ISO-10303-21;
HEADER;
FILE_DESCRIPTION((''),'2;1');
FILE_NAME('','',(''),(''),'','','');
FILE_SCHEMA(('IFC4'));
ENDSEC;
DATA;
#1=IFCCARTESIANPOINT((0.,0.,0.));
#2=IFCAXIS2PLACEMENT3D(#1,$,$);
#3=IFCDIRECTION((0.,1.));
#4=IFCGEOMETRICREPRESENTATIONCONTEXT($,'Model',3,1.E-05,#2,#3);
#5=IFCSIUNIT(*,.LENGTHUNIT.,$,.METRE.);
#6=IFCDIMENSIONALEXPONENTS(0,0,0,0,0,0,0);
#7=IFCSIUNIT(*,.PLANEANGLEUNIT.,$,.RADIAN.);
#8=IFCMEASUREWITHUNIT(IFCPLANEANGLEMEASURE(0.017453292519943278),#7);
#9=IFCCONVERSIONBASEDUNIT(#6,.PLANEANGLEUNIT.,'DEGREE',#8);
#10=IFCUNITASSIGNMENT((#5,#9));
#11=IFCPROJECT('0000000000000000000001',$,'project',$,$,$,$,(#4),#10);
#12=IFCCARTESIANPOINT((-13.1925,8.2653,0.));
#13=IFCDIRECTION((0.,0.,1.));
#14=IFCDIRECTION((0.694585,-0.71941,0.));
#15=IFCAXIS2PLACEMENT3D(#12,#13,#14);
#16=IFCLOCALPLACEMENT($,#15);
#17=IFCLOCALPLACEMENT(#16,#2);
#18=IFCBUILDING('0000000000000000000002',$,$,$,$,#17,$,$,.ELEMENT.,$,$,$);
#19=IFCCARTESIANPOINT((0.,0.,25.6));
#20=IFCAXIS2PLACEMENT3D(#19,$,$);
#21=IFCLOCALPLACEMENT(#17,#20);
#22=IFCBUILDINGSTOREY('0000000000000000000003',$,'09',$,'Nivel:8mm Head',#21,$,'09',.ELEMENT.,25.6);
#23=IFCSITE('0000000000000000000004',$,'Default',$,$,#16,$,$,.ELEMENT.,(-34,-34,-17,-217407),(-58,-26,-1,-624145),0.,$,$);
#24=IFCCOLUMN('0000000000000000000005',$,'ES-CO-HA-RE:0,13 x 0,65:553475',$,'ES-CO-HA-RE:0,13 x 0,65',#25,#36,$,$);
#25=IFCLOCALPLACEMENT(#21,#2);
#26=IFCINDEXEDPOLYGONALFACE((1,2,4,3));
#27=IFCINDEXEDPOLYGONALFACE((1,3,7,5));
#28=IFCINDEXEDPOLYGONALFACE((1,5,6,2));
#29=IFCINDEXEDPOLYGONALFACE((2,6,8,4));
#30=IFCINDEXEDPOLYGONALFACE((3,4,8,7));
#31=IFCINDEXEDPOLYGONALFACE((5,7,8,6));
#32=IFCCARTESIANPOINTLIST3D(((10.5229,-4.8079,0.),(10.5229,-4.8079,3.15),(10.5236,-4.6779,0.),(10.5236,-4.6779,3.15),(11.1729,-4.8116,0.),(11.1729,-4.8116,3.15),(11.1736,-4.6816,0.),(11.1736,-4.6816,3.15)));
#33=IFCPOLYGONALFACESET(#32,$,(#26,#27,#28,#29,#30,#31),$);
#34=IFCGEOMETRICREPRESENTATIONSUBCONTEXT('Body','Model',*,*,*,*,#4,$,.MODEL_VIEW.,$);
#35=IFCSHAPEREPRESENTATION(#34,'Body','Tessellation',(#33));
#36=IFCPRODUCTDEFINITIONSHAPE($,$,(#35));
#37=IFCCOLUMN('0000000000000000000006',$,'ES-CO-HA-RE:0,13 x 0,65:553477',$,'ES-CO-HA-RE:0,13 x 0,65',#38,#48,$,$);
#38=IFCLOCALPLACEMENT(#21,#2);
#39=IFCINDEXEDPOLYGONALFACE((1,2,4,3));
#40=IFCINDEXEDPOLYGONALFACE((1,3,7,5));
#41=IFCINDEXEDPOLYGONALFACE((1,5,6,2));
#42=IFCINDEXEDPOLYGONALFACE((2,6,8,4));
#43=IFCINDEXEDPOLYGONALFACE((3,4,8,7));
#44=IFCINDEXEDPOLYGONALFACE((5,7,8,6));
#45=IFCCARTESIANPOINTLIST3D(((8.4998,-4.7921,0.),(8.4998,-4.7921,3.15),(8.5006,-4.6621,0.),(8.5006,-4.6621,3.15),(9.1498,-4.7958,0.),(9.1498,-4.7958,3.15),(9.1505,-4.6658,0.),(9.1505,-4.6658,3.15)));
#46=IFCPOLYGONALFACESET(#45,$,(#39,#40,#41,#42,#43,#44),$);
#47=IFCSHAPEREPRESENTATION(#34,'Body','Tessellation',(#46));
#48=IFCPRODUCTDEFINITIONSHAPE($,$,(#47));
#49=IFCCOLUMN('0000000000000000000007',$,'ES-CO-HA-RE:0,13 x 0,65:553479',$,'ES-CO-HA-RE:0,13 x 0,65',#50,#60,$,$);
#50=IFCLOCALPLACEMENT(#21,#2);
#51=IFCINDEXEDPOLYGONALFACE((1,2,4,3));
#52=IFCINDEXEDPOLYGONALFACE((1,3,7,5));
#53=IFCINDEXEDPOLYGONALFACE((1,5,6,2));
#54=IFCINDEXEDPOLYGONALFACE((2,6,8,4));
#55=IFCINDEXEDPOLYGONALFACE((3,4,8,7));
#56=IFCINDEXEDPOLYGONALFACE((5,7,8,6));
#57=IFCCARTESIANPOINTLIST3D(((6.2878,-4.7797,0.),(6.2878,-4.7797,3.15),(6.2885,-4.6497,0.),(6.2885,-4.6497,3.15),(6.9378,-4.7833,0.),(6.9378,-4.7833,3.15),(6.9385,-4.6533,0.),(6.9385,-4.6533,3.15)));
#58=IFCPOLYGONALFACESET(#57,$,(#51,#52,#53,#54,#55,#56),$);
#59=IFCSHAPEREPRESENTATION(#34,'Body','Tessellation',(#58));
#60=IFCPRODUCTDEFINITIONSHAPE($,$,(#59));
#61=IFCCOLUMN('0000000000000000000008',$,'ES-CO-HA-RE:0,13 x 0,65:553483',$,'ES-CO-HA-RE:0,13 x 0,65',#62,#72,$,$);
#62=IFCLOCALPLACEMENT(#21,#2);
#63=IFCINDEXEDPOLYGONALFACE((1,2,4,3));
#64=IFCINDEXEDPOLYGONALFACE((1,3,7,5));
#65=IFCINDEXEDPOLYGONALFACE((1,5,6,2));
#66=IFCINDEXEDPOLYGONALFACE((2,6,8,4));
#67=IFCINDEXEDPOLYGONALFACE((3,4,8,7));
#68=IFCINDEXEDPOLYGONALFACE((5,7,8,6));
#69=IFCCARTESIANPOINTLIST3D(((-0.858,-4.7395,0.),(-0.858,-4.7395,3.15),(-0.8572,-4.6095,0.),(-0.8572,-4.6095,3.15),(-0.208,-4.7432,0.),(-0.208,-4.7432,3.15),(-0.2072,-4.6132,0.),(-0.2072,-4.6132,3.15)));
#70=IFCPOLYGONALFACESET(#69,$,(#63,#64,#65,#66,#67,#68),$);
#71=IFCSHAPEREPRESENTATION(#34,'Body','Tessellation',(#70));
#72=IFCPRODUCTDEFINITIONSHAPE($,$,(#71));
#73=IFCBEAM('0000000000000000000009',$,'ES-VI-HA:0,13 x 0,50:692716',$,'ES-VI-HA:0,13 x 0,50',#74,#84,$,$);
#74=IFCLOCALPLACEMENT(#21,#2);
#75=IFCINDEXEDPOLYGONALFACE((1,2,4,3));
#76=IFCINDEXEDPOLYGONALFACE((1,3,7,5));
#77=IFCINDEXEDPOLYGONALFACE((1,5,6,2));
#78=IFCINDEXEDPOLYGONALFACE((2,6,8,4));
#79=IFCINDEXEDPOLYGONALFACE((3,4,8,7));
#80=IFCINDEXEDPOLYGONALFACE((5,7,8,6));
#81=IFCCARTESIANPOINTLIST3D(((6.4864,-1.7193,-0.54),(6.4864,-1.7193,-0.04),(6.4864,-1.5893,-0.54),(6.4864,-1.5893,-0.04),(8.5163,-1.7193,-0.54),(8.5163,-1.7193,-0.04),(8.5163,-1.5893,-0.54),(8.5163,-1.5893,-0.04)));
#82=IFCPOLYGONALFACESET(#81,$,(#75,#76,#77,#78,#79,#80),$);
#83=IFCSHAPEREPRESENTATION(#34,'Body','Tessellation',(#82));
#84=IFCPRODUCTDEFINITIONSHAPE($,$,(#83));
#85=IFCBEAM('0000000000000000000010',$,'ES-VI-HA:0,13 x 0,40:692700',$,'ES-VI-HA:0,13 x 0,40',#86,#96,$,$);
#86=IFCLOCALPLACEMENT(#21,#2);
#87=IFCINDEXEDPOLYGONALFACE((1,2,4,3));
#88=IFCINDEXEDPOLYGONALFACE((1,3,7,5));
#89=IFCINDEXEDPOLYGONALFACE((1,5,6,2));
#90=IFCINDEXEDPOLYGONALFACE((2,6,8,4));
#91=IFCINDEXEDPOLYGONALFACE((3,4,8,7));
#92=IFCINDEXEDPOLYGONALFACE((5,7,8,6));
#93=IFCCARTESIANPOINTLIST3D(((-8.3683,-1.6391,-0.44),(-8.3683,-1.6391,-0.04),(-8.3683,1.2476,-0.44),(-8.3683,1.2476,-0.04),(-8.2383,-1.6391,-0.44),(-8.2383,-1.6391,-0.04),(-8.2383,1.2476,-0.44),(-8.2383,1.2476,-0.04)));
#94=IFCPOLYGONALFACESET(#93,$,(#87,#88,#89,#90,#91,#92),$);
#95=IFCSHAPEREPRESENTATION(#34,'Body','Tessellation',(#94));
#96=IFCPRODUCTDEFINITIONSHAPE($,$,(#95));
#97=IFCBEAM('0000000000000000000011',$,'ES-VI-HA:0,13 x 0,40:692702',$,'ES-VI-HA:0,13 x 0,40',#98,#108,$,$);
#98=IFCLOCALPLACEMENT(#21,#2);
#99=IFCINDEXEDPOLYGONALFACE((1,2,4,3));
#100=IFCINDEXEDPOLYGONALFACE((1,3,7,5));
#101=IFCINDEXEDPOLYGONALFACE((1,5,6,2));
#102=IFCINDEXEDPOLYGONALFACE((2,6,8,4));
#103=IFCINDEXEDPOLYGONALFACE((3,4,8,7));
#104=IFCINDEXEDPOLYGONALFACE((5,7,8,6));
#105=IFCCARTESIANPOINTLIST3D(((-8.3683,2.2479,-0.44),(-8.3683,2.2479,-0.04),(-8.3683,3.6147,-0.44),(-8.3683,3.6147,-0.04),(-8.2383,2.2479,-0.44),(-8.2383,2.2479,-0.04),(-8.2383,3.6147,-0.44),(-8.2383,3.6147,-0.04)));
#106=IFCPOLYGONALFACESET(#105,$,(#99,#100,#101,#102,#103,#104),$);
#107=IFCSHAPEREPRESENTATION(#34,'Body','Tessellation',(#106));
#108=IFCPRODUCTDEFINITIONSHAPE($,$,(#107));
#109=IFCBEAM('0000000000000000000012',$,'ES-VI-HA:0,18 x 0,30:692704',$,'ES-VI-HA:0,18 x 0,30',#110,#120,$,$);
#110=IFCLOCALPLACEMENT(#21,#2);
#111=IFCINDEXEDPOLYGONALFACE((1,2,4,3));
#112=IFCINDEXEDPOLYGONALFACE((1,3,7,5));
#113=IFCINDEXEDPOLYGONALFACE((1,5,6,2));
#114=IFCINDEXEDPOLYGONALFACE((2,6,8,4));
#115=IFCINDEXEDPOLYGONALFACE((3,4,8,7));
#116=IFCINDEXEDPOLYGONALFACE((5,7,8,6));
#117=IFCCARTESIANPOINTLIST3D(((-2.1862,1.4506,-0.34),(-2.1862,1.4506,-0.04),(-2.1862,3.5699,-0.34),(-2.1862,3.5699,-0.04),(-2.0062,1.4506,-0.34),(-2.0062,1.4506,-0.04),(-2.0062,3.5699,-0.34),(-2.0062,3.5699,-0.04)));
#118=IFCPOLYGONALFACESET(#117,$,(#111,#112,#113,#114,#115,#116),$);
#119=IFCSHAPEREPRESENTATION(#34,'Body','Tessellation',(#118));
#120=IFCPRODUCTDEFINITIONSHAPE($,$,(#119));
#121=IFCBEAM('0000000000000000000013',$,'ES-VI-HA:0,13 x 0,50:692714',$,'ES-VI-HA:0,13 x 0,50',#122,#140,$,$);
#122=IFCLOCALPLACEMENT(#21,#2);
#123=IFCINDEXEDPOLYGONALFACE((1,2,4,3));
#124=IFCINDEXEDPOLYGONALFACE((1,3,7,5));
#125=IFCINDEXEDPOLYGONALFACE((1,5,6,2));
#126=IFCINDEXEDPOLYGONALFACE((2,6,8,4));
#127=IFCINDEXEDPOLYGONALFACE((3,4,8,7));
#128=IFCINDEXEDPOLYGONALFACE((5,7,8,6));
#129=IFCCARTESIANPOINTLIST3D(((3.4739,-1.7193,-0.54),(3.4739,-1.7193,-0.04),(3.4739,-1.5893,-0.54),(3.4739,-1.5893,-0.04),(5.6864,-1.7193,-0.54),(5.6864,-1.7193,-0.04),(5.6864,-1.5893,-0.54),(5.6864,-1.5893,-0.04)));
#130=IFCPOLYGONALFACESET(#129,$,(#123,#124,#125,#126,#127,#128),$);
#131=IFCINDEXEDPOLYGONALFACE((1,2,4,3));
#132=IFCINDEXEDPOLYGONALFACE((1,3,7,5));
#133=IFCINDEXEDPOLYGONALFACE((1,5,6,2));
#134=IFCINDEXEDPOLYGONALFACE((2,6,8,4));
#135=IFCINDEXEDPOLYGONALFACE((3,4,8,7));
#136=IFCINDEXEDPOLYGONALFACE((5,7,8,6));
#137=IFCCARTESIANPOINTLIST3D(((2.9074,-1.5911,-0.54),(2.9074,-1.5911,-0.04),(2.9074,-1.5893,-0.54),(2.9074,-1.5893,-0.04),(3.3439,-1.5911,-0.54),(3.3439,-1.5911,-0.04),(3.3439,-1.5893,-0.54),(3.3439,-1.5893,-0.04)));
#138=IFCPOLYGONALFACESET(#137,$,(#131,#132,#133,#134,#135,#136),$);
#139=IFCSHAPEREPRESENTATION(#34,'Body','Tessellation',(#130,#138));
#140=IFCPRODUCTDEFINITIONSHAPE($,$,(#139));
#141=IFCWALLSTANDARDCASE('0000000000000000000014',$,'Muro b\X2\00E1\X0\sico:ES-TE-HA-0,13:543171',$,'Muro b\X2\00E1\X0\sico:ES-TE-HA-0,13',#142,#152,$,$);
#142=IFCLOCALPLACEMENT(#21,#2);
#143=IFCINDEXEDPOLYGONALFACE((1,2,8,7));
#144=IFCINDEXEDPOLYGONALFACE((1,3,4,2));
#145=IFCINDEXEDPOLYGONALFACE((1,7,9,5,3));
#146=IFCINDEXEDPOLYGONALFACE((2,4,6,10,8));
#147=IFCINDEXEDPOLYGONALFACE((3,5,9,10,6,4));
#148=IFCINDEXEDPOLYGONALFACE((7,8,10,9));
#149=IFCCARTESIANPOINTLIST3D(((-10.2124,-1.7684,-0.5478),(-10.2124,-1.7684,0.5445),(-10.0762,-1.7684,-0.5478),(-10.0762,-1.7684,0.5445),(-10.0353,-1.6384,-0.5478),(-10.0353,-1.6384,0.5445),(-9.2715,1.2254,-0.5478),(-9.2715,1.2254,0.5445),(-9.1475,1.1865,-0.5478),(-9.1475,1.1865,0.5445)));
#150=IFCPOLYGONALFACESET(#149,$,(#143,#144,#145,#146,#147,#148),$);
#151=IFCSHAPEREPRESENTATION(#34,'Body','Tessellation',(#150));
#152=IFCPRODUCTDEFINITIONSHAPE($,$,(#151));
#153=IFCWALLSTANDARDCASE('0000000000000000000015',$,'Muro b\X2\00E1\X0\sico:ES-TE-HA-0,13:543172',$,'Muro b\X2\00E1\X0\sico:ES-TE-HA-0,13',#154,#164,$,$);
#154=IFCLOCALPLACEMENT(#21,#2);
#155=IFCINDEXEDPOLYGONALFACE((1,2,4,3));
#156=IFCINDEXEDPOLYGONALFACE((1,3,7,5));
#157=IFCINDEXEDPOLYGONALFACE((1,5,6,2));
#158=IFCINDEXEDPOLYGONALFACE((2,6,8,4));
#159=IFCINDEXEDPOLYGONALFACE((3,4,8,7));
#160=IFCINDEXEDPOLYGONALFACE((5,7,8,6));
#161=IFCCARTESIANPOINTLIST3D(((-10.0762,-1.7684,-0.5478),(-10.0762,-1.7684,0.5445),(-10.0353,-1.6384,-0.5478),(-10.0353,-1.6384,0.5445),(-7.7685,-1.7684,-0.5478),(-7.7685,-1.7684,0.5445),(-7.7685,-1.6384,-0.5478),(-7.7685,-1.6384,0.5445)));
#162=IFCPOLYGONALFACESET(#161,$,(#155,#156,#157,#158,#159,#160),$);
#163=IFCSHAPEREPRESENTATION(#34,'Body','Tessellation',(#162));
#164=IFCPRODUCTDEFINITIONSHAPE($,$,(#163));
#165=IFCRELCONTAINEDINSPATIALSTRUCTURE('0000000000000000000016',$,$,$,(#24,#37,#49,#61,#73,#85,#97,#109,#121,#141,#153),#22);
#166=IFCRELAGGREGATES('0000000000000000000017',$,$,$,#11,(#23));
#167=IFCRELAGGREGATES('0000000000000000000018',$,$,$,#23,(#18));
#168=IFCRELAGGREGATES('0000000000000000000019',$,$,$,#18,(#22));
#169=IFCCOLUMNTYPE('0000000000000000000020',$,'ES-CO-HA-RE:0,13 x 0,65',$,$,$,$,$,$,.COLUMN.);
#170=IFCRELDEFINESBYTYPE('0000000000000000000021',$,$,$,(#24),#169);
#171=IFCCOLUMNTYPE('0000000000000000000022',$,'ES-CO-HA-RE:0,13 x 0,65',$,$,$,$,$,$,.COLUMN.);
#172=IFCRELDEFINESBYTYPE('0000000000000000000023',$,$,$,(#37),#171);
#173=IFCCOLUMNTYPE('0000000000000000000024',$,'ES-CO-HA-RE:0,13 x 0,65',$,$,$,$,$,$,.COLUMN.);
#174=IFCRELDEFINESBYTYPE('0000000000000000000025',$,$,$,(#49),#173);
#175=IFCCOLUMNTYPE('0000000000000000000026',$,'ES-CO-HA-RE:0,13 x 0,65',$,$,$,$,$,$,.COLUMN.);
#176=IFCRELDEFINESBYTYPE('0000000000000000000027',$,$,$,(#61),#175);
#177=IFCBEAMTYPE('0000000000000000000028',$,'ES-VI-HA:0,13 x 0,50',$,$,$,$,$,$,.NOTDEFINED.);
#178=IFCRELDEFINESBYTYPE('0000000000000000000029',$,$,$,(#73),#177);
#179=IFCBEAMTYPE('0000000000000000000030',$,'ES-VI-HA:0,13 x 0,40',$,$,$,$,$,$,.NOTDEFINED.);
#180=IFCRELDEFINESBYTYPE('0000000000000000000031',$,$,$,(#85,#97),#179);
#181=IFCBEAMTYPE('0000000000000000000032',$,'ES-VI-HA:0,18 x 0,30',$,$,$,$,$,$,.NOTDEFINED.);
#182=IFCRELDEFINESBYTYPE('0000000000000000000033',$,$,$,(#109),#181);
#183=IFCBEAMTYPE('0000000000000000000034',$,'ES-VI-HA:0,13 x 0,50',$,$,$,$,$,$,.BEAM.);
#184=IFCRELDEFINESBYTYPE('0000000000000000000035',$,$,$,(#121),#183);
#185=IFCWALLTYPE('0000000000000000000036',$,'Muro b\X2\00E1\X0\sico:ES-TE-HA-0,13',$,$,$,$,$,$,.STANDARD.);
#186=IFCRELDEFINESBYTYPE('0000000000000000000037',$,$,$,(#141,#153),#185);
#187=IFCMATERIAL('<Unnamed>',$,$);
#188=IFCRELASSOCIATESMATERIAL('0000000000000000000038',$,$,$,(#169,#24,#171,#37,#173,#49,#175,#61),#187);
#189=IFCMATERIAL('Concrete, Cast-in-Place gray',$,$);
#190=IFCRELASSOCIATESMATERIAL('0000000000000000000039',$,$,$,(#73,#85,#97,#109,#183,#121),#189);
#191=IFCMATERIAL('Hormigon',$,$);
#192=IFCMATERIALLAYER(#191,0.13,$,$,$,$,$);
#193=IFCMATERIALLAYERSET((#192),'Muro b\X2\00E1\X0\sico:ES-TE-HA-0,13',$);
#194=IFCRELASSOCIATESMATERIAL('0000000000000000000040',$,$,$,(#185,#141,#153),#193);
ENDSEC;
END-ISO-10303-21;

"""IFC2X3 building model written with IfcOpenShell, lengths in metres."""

from ifc_helpers import new_model, entity, si_unit, converted_unit, direction, frame, frame_2d, origin, origin_2d_with_axis, place, context, subcontext, project, spatial, polyline, rectangle, outline, extrude, source, transform, mapped, material, layer, layer_set, layer_usage, type_object, type_shapes, element, save


model = new_model("IFC2X3")

# Units and contexts
model_context = context("Model", 3, precision=1e-05, world=origin(), true_north=direction((0.0, 1.0)))
body_context = subcontext(model_context, "Body", "Model", "MODEL_VIEW")
ifc_project = project(units=[si_unit("LENGTHUNIT", "METRE"), converted_unit("PLANEANGLEUNIT", "DEGREE", entity("IfcPlaneAngleMeasure", 0.017453292519943278), si_unit("PLANEANGLEUNIT", "RADIAN"), dimensions=[0, 0, 0, 0, 0, 0, 0])], contexts=[model_context])

# Site, building, storey
site_placement = place(None, frame((-13.1925, 8.2653, 0.0), z_axis=(0.0, 0.0, 1.0), x_axis=(0.694585, -0.71941, 0.0)))
site = spatial("IfcSite", under=ifc_project, at=site_placement, Name="Default", CompositionType="ELEMENT", RefLatitude=(-34, -34, -17, -217407), RefLongitude=(-58, -26, -1, -624145), RefElevation=0.0)
building_placement = place(site_placement, origin())
building = spatial("IfcBuilding", under=site, at=building_placement, CompositionType="ELEMENT")
storey_placement = place(building_placement, frame((0.0, 0.0, 25.6)))
storey = spatial("IfcBuildingStorey", under=building, at=storey_placement, Name="09", ObjectType="Nivel:8mm Head", LongName="09", CompositionType="ELEMENT", Elevation=25.6)

# Columns
ifc_material_1 = material(Name="<Unnamed>")
ifc_material_2 = material(Name="Hormigon")
column_type_1 = type_object("IfcColumnType", Name="ES-CO-HA-RE:0,13 x 0,65", PredefinedType="COLUMN", material=ifc_material_1)
shared_shape_1 = source(origin(), body_context, "Body", "SweptSolid", [
    extrude(rectangle(XDim=0.65, YDim=0.13, at=frame_2d((0.0, 0.0), x_axis=(1.0, 0.0))), frame((10.8483, -4.7447, 25.6), z_axis=(0.0, 0.0, 1.0), x_axis=(-0.999984, 0.005619, 0.0)), (0.0, 0.0, 1.0), 3.15),
])
type_shapes(column_type_1, [shared_shape_1])
column_1_placement = place(storey_placement, frame((0.0, 0.0, -25.6)))
element("IfcColumn", 1, at=column_1_placement, inside=storey, type_object=column_type_1, material=ifc_material_1, Name="ES-CO-HA-RE:0,13 x 0,65:553475", ObjectType="ES-CO-HA-RE:0,13 x 0,65", context=body_context, shape_type="MappedRepresentation", body=[
    mapped(shared_shape_1, transform((0.0, 0.0, 0.0), scale=1.0)),
])
column_type_2 = type_object("IfcColumnType", Name="ES-CO-HA-RE:0,13 x 0,65", PredefinedType="COLUMN", material=ifc_material_1)
shared_shape_2 = source(origin(), body_context, "Body", "SweptSolid", [
    extrude(rectangle(XDim=0.65, YDim=0.13, at=origin_2d_with_axis()), frame((8.8252, -4.7289, 25.6), z_axis=(0.0, 0.0, 1.0), x_axis=(-0.999984, 0.005619, 0.0)), (0.0, 0.0, 1.0), 3.15),
])
type_shapes(column_type_2, [shared_shape_2])
column_2_placement = place(storey_placement, frame((0.0, 0.0, -25.6)))
element("IfcColumn", 2, at=column_2_placement, inside=storey, type_object=column_type_2, material=ifc_material_1, Name="ES-CO-HA-RE:0,13 x 0,65:553477", ObjectType="ES-CO-HA-RE:0,13 x 0,65", context=body_context, shape_type="MappedRepresentation", body=[
    mapped(shared_shape_2, transform((0.0, 0.0, 0.0), scale=1.0)),
])
column_type_3 = type_object("IfcColumnType", Name="ES-CO-HA-RE:0,13 x 0,65", PredefinedType="COLUMN", material=ifc_material_1)
shared_shape_3 = source(origin(), body_context, "Body", "SweptSolid", [
    extrude(rectangle(XDim=0.65, YDim=0.13, at=frame_2d((0.0, 0.0), x_axis=(1.0, 0.0))), frame((6.6131, -4.7165, 25.6), z_axis=(0.0, 0.0, 1.0), x_axis=(-0.999984, 0.005619, 0.0)), (0.0, 0.0, 1.0), 3.15),
])
type_shapes(column_type_3, [shared_shape_3])
column_3_placement = place(storey_placement, frame((0.0, 0.0, -25.6)))
element("IfcColumn", 3, at=column_3_placement, inside=storey, type_object=column_type_3, material=ifc_material_1, Name="ES-CO-HA-RE:0,13 x 0,65:553479", ObjectType="ES-CO-HA-RE:0,13 x 0,65", context=body_context, shape_type="MappedRepresentation", body=[
    mapped(shared_shape_3, transform((0.0, 0.0, 0.0), scale=1.0)),
])
column_type_4 = type_object("IfcColumnType", Name="ES-CO-HA-RE:0,13 x 0,65", PredefinedType="COLUMN", material=ifc_material_1)
shared_shape_4 = source(origin(), body_context, "Body", "SweptSolid", [
    extrude(rectangle(XDim=0.65, YDim=0.13, at=frame_2d((0.0, 0.0), x_axis=(1.0, 0.0))), frame((-0.5326, -4.6764, 25.6), z_axis=(0.0, 0.0, 1.0), x_axis=(-0.999984, 0.005619, 0.0)), (0.0, 0.0, 1.0), 3.15),
])
type_shapes(column_type_4, [shared_shape_4])
column_4_placement = place(storey_placement, frame((0.0, 0.0, -25.6)))
element("IfcColumn", 4, at=column_4_placement, inside=storey, type_object=column_type_4, material=ifc_material_1, Name="ES-CO-HA-RE:0,13 x 0,65:553483", ObjectType="ES-CO-HA-RE:0,13 x 0,65", context=body_context, shape_type="MappedRepresentation", body=[
    mapped(shared_shape_4, transform((0.0, 0.0, 0.0), scale=1.0)),
])

# Beams
ifc_material_3 = material(Name="Concrete, Cast-in-Place gray")
beam_type_1 = type_object("IfcBeamType", Name="ES-VI-HA:0,13 x 0,50", PredefinedType="NOTDEFINED")
beam_1_placement = place(storey_placement, frame((5.7373, -1.6543, -0.04)))
element("IfcBeam", 5, at=beam_1_placement, inside=storey, type_object=beam_type_1, material=ifc_material_3, Name="ES-VI-HA:0,13 x 0,50:692716", ObjectType="ES-VI-HA:0,13 x 0,50", context=body_context, shape_type="SweptSolid", body=[
    extrude(rectangle(XDim=0.5, YDim=0.13, at=frame_2d((0.0, 0.0), x_axis=(1.0, 0.0))), frame((0.7491, 0.0, -0.25), z_axis=(1.0, 0.0, 0.0), x_axis=(0.0, 0.0, -1.0)), (0.0, 0.0, 1.0), 2.0299),
])
beam_type_2 = type_object("IfcBeamType", Name="ES-VI-HA:0,13 x 0,40", PredefinedType="NOTDEFINED")
beam_2_placement = place(storey_placement, frame((-8.3033, -1.6391, -0.04), z_axis=(0.0, 0.0, 1.0), x_axis=(0.0, 1.0, 0.0)))
element("IfcBeam", 6, at=beam_2_placement, inside=storey, type_object=beam_type_2, material=ifc_material_3, Name="ES-VI-HA:0,13 x 0,40:692700", ObjectType="ES-VI-HA:0,13 x 0,40", context=body_context, shape_type="SweptSolid", body=[
    extrude(rectangle(XDim=0.4, YDim=0.13, at=frame_2d((0.0, 0.0), x_axis=(1.0, 0.0))), frame((0.0, 0.0, -0.2), z_axis=(1.0, 0.0, 0.0), x_axis=(0.0, 0.0, -1.0)), (0.0, 0.0, 1.0), 2.8867),
])
beam_3_placement = place(storey_placement, frame((-8.3033, 2.2479, -0.04), z_axis=(0.0, 0.0, 1.0), x_axis=(0.0, 1.0, 0.0)))
element("IfcBeam", 7, at=beam_3_placement, inside=storey, type_object=beam_type_2, material=ifc_material_3, Name="ES-VI-HA:0,13 x 0,40:692702", ObjectType="ES-VI-HA:0,13 x 0,40", context=body_context, shape_type="SweptSolid", body=[
    extrude(rectangle(XDim=0.4, YDim=0.13, at=frame_2d((0.0, 0.0), x_axis=(1.0, 0.0))), frame((0.0, 0.0, -0.2), z_axis=(1.0, 0.0, 0.0), x_axis=(0.0, 0.0, -1.0)), (0.0, 0.0, 1.0), 1.3668),
])
beam_type_3 = type_object("IfcBeamType", Name="ES-VI-HA:0,18 x 0,30", PredefinedType="NOTDEFINED")
beam_4_placement = place(storey_placement, frame((-2.0962, 3.5699, -0.04), z_axis=(0.0, 0.0, 1.0), x_axis=(0.0, -1.0, 0.0)))
element("IfcBeam", 8, at=beam_4_placement, inside=storey, type_object=beam_type_3, material=ifc_material_3, Name="ES-VI-HA:0,18 x 0,30:692704", ObjectType="ES-VI-HA:0,18 x 0,30", context=body_context, shape_type="SweptSolid", body=[
    extrude(rectangle(XDim=0.3, YDim=0.18, at=origin_2d_with_axis()), frame((0.0, 0.0, -0.15), z_axis=(1.0, 0.0, 0.0), x_axis=(0.0, 0.0, -1.0)), (0.0, 0.0, 1.0), 2.1193),
])
beam_type_4 = type_object("IfcBeamType", Name="ES-VI-HA:0,13 x 0,50", PredefinedType="BEAM", material=ifc_material_3)
shared_shape_5 = source(origin(), body_context, "Body", "SweptSolid", [
    extrude(rectangle(XDim=0.5, YDim=0.13, at=frame_2d((0.0, 0.0), x_axis=(1.0, 0.0))), frame((3.4739, -1.6543, 25.31), z_axis=(1.0, 0.0, 0.0), x_axis=(0.0, 0.0, -1.0)), (0.0, 0.0, 1.0), 2.2125),
    extrude(rectangle(XDim=0.5, YDim=0.0018, at=frame_2d((0.0, 0.0), x_axis=(1.0, 0.0))), frame((2.9074, -1.5902, 25.31), z_axis=(1.0, 0.0, 0.0), x_axis=(0.0, 0.0, -1.0)), (0.0, 0.0, 1.0), 0.4365),
])
type_shapes(beam_type_4, [shared_shape_5])
beam_5_placement = place(storey_placement, frame((0.0, 0.0, -25.6)))
element("IfcBeam", 9, at=beam_5_placement, inside=storey, type_object=beam_type_4, material=ifc_material_3, Name="ES-VI-HA:0,13 x 0,50:692714", ObjectType="ES-VI-HA:0,13 x 0,50", context=body_context, shape_type="MappedRepresentation", body=[
    mapped(shared_shape_5, transform((0.0, 0.0, 0.0), scale=1.0)),
])

# Walls
ifc_layer_1 = layer(ifc_material_2, 0.13)
ifc_layer_set_1 = layer_set([ifc_layer_1], Name="Muro básico:ES-TE-HA-0,13")
ifc_layer_usage_1 = layer_usage(ifc_layer_set_1, "AXIS2", "NEGATIVE", 0.065)
wall_type = type_object("IfcWallType", Name="Muro básico:ES-TE-HA-0,13", PredefinedType="STANDARD", material=ifc_layer_set_1)
wall_1_placement = place(storey_placement, frame((-10.1504, -1.7879, -0.5478), z_axis=(0.0, 0.0, 1.0), x_axis=(0.299835, 0.953991, 0.0)))
element("IfcWallStandardCase", 10, at=wall_1_placement, inside=storey, type_object=wall_type, material=ifc_layer_usage_1, Name="Muro básico:ES-TE-HA-0,13:543171", ObjectType="Muro básico:ES-TE-HA-0,13", context=body_context, shape_type="SweptSolid", body=[
    extrude(outline(polyline([(3.1382, -0.065), (3.1382, 0.065), (0.0, 0.065), (0.0409, -0.065), (0.1771, -0.065), (3.1382, -0.065)])), origin(), (0.0, 0.0, 1.0), 1.0923),
])
ifc_layer_usage_2 = layer_usage(ifc_layer_set_1, "AXIS2", "POSITIVE", -0.065)
wall_2_placement = place(storey_placement, frame((-10.0762, -1.7034, -0.5478)))
element("IfcWallStandardCase", 11, at=wall_2_placement, inside=storey, type_object=wall_type, material=ifc_layer_usage_2, Name="Muro básico:ES-TE-HA-0,13:543172", ObjectType="Muro básico:ES-TE-HA-0,13", context=body_context, shape_type="SweptSolid", body=[
    extrude(outline(polyline([(2.3077, -0.065), (2.3077, 0.065), (0.0409, 0.065), (0.0, -0.065), (2.3077, -0.065)])), origin(), (0.0, 0.0, 1.0), 1.0923),
])

save(model, "model.ifc")
